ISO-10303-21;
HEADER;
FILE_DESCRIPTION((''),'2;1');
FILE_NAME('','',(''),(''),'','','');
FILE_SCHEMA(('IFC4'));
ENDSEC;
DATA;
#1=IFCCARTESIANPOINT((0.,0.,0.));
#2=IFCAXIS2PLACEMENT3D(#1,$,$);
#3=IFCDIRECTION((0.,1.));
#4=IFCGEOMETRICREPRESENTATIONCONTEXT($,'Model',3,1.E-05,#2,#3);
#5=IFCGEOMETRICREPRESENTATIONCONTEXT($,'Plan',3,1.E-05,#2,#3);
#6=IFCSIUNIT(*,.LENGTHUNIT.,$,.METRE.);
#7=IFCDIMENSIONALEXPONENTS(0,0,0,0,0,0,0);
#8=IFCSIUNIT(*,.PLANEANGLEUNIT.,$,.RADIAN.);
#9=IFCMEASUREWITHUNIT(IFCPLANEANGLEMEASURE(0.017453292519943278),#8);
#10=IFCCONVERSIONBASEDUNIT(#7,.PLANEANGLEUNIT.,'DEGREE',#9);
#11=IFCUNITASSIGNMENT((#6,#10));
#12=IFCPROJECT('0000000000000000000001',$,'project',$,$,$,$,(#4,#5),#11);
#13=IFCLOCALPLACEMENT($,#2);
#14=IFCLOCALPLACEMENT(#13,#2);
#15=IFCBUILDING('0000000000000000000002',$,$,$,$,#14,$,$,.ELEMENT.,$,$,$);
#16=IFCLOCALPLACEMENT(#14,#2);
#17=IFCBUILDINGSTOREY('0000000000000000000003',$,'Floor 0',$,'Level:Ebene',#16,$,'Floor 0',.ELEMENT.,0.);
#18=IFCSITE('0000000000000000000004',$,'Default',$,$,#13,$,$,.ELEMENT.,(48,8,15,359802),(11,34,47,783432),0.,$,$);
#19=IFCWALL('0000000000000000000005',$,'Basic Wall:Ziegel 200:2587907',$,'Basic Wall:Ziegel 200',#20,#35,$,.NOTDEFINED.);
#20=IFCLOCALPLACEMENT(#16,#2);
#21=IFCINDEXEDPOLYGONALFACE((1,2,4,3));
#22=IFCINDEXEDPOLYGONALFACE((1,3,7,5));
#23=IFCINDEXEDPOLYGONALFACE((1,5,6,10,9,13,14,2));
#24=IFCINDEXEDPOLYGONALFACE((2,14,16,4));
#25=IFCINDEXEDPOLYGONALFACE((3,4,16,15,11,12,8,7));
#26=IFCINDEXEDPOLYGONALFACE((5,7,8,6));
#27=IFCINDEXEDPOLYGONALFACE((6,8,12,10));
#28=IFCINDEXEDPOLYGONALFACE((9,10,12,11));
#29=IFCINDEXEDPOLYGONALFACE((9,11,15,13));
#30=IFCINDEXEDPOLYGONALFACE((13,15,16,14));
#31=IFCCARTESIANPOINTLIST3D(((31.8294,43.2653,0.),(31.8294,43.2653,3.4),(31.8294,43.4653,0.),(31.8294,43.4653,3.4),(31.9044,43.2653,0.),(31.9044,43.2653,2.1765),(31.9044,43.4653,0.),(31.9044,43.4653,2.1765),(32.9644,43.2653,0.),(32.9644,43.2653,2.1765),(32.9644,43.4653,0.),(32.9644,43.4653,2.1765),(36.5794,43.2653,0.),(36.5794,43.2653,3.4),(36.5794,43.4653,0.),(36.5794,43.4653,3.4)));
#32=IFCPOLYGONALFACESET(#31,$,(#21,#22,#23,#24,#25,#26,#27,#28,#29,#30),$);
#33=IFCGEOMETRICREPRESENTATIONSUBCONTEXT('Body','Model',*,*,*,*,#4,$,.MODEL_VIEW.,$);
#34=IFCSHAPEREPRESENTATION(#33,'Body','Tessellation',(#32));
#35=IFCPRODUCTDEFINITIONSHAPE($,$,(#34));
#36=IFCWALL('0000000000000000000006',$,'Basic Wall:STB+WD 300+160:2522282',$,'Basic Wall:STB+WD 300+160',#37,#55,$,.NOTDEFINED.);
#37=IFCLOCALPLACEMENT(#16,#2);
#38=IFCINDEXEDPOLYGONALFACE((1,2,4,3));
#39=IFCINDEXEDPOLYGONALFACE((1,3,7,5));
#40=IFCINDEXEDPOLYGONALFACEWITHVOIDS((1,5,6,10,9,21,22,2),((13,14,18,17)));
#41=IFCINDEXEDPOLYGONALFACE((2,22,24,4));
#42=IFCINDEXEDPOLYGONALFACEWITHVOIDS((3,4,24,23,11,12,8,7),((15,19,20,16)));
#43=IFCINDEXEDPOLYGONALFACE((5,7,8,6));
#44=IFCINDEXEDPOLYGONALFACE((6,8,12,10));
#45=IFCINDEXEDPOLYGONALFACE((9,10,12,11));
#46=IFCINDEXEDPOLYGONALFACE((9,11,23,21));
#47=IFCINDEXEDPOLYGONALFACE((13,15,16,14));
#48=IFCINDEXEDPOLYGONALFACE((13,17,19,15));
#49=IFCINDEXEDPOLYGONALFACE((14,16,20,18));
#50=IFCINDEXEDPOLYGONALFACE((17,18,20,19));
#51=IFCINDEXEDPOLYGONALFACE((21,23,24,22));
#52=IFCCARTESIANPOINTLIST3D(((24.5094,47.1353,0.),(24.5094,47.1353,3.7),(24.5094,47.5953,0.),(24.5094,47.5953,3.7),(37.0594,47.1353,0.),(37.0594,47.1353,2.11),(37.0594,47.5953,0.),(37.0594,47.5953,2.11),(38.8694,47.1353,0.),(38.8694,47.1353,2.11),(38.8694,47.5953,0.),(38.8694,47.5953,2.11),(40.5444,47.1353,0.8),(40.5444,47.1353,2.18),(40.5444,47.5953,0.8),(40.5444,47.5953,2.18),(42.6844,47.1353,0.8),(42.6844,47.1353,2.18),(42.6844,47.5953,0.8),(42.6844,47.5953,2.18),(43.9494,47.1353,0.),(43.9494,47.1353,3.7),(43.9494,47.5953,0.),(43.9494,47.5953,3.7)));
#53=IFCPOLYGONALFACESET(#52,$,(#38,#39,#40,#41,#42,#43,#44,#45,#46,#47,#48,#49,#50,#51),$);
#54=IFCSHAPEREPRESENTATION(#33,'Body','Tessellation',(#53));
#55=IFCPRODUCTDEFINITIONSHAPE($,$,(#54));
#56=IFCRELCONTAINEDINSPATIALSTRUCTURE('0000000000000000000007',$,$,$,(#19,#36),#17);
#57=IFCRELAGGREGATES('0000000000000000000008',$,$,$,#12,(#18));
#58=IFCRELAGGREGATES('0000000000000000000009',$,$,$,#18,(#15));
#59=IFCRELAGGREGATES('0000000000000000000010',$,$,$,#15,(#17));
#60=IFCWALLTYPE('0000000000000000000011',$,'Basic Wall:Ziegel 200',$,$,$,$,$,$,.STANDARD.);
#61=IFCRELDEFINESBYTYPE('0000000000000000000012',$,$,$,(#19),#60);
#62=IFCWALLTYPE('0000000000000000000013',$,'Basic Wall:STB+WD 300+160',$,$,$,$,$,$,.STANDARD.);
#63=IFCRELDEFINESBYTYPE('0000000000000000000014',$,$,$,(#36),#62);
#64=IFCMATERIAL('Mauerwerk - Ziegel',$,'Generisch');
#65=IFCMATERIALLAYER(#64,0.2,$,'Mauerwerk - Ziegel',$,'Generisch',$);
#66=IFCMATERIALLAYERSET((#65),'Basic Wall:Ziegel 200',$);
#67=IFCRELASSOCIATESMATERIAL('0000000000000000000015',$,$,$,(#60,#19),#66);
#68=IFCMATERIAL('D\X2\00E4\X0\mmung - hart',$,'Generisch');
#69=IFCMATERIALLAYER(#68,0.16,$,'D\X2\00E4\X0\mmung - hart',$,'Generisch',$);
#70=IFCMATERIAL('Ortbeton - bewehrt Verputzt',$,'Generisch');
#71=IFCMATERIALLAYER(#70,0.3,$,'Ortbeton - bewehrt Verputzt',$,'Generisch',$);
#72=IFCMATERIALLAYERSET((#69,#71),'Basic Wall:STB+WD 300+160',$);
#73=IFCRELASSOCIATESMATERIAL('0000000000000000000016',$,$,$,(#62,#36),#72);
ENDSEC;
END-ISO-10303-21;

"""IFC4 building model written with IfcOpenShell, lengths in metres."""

from ifc_helpers import new_model, entity, si_unit, converted_unit, direction, frame, frame_2d, origin, place, context, subcontext, project, spatial, polyline, rectangle, extrude, clip, bounded_halfspace, material, layer, layer_set, layer_usage, type_object, element, save


model = new_model("IFC4")

# Units and contexts
model_context = context("Model", 3, precision=1e-05, world=origin(), true_north=direction((0.0, 1.0)))
plan_context = context("Plan", 3, precision=1e-05, world=origin(), true_north=direction((0.0, 1.0)))
body_context = subcontext(model_context, "Body", "Model", "MODEL_VIEW")
ifc_project = project(units=[si_unit("LENGTHUNIT", "METRE"), converted_unit("PLANEANGLEUNIT", "DEGREE", entity("IfcPlaneAngleMeasure", 0.017453292519943278), si_unit("PLANEANGLEUNIT", "RADIAN"), dimensions=[0, 0, 0, 0, 0, 0, 0])], contexts=[model_context, plan_context])

# Site, building, storey
site_placement = place(None, origin())
site = spatial("IfcSite", under=ifc_project, at=site_placement, Name="Default", CompositionType="ELEMENT", RefLatitude=(48, 8, 15, 359802), RefLongitude=(11, 34, 47, 783432), RefElevation=0.0)
building_placement = place(site_placement, origin())
building = spatial("IfcBuilding", under=site, at=building_placement, CompositionType="ELEMENT")
storey_placement = place(building_placement, origin())
storey = spatial("IfcBuildingStorey", under=building, at=storey_placement, Name="Floor 0", ObjectType="Level:Ebene", LongName="Floor 0", CompositionType="ELEMENT", Elevation=0.0)

# Shared definitions
ifc_material_1 = material(Name="Ortbeton - bewehrt Verputzt", Category="Generisch")
ifc_material_2 = material(Name="Mauerwerk - Ziegel", Category="Generisch")
ifc_layer_1 = layer(ifc_material_2, 0.2, Name="Mauerwerk - Ziegel", Category="Generisch")
ifc_layer_set_1 = layer_set([ifc_layer_1], Name="Basic Wall:Ziegel 200")
ifc_layer_usage_1 = layer_usage(ifc_layer_set_1, "AXIS2", "NEGATIVE", 0.1)
wall_type_1 = type_object("IfcWallType", Name="Basic Wall:Ziegel 200", PredefinedType="STANDARD", material=ifc_layer_set_1)

# Wall, opening
wall_1_placement = place(storey_placement, frame((31.8294, 43.3653, 0.0)))
wall_1 = element("IfcWall", 1, at=wall_1_placement, inside=storey, type_object=wall_type_1, material=ifc_layer_usage_1, Name="Basic Wall:Ziegel 200:2587907", ObjectType="Basic Wall:Ziegel 200", PredefinedType="NOTDEFINED", context=body_context, shape_type="Clipping", body=[
    clip(extrude(rectangle(XDim=4.75, YDim=0.2, at=frame_2d((2.375, 0.0), x_axis=(-1.0, 0.0))), origin(), (0.0, 0.0, 1.0), 3.4), bounded_halfspace(frame((0.0, -0.1, 3.4), z_axis=(0.0, 0.0, -1.0), x_axis=(-1.0, 0.0, 0.0)), True, frame((0.0, -0.1, 3.4)), polyline([(0.0, 0.0), (4.75, 0.0), (4.75, 0.2), (0.0, 0.2), (0.0, 0.0)]))),
])
opening_1_placement = place(wall_1_placement, frame((1.135, 0.1, 0.0)))
element("IfcOpeningElement", 2, at=opening_1_placement, cuts=wall_1, PredefinedType="OPENING", context=body_context, shape_type="SweptSolid", body=[
    extrude(rectangle(XDim=2.1765, YDim=1.06, at=frame_2d((1.0882, 0.53), x_axis=(1.0, 0.0))), frame((0.0, 0.0, 0.0), z_axis=(0.0, -1.0, 0.0), x_axis=(0.0, 0.0, 1.0)), (0.0, 0.0, 1.0), 0.2),
])

# Wall, openings
ifc_material_3 = material(Name="Dämmung - hart", Category="Generisch")
ifc_layer_2 = layer(ifc_material_3, 0.16, Name="Dämmung - hart", Category="Generisch")
ifc_layer_3 = layer(ifc_material_1, 0.3, Name="Ortbeton - bewehrt Verputzt", Category="Generisch")
ifc_layer_set_2 = layer_set([ifc_layer_2, ifc_layer_3], Name="Basic Wall:STB+WD 300+160")
ifc_layer_usage_2 = layer_usage(ifc_layer_set_2, "AXIS2", "POSITIVE", -0.23)
wall_type_2 = type_object("IfcWallType", Name="Basic Wall:STB+WD 300+160", PredefinedType="STANDARD", material=ifc_layer_set_2)
wall_2_placement = place(storey_placement, frame((43.9494, 47.3653, 0.0), z_axis=(0.0, 0.0, 1.0), x_axis=(-1.0, 0.0, 0.0)))
wall_2 = element("IfcWall", 3, at=wall_2_placement, inside=storey, type_object=wall_type_2, material=ifc_layer_usage_2, Name="Basic Wall:STB+WD 300+160:2522282", ObjectType="Basic Wall:STB+WD 300+160", PredefinedType="NOTDEFINED", context=body_context, shape_type="SweptSolid", body=[
    extrude(rectangle(XDim=19.44, YDim=0.46, at=frame_2d((9.72, 0.0), x_axis=(-1.0, 0.0))), origin(), (0.0, 0.0, 1.0), 3.7),
])
opening_2_placement = place(wall_2_placement, frame((5.08, -0.23, 0.0)))
element("IfcOpeningElement", 4, at=opening_2_placement, cuts=wall_2, PredefinedType="OPENING", context=body_context, shape_type="SweptSolid", body=[
    extrude(rectangle(XDim=2.11, YDim=1.81, at=frame_2d((1.055, 0.905), x_axis=(1.0, 0.0))), frame((0.0, 0.0, 0.0), z_axis=(0.0, 1.0, 0.0), x_axis=(0.0, 0.0, 1.0)), (0.0, 0.0, 1.0), 0.46),
])
opening_3_placement = place(wall_2_placement, frame((43.9494, 47.3653, 0.8), z_axis=(0.0, 0.0, 1.0), x_axis=(-1.0, 0.0, 0.0)))
element("IfcOpeningElement", 5, at=opening_3_placement, cuts=wall_2, PredefinedType="OPENING", context=body_context, shape_type="SweptSolid", body=[
    extrude(rectangle(XDim=1.38, YDim=2.14, at=frame_2d((0.0, 0.0), x_axis=(0.0, 1.0))), frame((41.6144, 48.6593, 0.69), z_axis=(0.0, -1.0, 0.0), x_axis=(1.0, 0.0, 0.0)), (0.0, 0.0, 1.0), 3.048),
])

save(model, "model.ifc")
